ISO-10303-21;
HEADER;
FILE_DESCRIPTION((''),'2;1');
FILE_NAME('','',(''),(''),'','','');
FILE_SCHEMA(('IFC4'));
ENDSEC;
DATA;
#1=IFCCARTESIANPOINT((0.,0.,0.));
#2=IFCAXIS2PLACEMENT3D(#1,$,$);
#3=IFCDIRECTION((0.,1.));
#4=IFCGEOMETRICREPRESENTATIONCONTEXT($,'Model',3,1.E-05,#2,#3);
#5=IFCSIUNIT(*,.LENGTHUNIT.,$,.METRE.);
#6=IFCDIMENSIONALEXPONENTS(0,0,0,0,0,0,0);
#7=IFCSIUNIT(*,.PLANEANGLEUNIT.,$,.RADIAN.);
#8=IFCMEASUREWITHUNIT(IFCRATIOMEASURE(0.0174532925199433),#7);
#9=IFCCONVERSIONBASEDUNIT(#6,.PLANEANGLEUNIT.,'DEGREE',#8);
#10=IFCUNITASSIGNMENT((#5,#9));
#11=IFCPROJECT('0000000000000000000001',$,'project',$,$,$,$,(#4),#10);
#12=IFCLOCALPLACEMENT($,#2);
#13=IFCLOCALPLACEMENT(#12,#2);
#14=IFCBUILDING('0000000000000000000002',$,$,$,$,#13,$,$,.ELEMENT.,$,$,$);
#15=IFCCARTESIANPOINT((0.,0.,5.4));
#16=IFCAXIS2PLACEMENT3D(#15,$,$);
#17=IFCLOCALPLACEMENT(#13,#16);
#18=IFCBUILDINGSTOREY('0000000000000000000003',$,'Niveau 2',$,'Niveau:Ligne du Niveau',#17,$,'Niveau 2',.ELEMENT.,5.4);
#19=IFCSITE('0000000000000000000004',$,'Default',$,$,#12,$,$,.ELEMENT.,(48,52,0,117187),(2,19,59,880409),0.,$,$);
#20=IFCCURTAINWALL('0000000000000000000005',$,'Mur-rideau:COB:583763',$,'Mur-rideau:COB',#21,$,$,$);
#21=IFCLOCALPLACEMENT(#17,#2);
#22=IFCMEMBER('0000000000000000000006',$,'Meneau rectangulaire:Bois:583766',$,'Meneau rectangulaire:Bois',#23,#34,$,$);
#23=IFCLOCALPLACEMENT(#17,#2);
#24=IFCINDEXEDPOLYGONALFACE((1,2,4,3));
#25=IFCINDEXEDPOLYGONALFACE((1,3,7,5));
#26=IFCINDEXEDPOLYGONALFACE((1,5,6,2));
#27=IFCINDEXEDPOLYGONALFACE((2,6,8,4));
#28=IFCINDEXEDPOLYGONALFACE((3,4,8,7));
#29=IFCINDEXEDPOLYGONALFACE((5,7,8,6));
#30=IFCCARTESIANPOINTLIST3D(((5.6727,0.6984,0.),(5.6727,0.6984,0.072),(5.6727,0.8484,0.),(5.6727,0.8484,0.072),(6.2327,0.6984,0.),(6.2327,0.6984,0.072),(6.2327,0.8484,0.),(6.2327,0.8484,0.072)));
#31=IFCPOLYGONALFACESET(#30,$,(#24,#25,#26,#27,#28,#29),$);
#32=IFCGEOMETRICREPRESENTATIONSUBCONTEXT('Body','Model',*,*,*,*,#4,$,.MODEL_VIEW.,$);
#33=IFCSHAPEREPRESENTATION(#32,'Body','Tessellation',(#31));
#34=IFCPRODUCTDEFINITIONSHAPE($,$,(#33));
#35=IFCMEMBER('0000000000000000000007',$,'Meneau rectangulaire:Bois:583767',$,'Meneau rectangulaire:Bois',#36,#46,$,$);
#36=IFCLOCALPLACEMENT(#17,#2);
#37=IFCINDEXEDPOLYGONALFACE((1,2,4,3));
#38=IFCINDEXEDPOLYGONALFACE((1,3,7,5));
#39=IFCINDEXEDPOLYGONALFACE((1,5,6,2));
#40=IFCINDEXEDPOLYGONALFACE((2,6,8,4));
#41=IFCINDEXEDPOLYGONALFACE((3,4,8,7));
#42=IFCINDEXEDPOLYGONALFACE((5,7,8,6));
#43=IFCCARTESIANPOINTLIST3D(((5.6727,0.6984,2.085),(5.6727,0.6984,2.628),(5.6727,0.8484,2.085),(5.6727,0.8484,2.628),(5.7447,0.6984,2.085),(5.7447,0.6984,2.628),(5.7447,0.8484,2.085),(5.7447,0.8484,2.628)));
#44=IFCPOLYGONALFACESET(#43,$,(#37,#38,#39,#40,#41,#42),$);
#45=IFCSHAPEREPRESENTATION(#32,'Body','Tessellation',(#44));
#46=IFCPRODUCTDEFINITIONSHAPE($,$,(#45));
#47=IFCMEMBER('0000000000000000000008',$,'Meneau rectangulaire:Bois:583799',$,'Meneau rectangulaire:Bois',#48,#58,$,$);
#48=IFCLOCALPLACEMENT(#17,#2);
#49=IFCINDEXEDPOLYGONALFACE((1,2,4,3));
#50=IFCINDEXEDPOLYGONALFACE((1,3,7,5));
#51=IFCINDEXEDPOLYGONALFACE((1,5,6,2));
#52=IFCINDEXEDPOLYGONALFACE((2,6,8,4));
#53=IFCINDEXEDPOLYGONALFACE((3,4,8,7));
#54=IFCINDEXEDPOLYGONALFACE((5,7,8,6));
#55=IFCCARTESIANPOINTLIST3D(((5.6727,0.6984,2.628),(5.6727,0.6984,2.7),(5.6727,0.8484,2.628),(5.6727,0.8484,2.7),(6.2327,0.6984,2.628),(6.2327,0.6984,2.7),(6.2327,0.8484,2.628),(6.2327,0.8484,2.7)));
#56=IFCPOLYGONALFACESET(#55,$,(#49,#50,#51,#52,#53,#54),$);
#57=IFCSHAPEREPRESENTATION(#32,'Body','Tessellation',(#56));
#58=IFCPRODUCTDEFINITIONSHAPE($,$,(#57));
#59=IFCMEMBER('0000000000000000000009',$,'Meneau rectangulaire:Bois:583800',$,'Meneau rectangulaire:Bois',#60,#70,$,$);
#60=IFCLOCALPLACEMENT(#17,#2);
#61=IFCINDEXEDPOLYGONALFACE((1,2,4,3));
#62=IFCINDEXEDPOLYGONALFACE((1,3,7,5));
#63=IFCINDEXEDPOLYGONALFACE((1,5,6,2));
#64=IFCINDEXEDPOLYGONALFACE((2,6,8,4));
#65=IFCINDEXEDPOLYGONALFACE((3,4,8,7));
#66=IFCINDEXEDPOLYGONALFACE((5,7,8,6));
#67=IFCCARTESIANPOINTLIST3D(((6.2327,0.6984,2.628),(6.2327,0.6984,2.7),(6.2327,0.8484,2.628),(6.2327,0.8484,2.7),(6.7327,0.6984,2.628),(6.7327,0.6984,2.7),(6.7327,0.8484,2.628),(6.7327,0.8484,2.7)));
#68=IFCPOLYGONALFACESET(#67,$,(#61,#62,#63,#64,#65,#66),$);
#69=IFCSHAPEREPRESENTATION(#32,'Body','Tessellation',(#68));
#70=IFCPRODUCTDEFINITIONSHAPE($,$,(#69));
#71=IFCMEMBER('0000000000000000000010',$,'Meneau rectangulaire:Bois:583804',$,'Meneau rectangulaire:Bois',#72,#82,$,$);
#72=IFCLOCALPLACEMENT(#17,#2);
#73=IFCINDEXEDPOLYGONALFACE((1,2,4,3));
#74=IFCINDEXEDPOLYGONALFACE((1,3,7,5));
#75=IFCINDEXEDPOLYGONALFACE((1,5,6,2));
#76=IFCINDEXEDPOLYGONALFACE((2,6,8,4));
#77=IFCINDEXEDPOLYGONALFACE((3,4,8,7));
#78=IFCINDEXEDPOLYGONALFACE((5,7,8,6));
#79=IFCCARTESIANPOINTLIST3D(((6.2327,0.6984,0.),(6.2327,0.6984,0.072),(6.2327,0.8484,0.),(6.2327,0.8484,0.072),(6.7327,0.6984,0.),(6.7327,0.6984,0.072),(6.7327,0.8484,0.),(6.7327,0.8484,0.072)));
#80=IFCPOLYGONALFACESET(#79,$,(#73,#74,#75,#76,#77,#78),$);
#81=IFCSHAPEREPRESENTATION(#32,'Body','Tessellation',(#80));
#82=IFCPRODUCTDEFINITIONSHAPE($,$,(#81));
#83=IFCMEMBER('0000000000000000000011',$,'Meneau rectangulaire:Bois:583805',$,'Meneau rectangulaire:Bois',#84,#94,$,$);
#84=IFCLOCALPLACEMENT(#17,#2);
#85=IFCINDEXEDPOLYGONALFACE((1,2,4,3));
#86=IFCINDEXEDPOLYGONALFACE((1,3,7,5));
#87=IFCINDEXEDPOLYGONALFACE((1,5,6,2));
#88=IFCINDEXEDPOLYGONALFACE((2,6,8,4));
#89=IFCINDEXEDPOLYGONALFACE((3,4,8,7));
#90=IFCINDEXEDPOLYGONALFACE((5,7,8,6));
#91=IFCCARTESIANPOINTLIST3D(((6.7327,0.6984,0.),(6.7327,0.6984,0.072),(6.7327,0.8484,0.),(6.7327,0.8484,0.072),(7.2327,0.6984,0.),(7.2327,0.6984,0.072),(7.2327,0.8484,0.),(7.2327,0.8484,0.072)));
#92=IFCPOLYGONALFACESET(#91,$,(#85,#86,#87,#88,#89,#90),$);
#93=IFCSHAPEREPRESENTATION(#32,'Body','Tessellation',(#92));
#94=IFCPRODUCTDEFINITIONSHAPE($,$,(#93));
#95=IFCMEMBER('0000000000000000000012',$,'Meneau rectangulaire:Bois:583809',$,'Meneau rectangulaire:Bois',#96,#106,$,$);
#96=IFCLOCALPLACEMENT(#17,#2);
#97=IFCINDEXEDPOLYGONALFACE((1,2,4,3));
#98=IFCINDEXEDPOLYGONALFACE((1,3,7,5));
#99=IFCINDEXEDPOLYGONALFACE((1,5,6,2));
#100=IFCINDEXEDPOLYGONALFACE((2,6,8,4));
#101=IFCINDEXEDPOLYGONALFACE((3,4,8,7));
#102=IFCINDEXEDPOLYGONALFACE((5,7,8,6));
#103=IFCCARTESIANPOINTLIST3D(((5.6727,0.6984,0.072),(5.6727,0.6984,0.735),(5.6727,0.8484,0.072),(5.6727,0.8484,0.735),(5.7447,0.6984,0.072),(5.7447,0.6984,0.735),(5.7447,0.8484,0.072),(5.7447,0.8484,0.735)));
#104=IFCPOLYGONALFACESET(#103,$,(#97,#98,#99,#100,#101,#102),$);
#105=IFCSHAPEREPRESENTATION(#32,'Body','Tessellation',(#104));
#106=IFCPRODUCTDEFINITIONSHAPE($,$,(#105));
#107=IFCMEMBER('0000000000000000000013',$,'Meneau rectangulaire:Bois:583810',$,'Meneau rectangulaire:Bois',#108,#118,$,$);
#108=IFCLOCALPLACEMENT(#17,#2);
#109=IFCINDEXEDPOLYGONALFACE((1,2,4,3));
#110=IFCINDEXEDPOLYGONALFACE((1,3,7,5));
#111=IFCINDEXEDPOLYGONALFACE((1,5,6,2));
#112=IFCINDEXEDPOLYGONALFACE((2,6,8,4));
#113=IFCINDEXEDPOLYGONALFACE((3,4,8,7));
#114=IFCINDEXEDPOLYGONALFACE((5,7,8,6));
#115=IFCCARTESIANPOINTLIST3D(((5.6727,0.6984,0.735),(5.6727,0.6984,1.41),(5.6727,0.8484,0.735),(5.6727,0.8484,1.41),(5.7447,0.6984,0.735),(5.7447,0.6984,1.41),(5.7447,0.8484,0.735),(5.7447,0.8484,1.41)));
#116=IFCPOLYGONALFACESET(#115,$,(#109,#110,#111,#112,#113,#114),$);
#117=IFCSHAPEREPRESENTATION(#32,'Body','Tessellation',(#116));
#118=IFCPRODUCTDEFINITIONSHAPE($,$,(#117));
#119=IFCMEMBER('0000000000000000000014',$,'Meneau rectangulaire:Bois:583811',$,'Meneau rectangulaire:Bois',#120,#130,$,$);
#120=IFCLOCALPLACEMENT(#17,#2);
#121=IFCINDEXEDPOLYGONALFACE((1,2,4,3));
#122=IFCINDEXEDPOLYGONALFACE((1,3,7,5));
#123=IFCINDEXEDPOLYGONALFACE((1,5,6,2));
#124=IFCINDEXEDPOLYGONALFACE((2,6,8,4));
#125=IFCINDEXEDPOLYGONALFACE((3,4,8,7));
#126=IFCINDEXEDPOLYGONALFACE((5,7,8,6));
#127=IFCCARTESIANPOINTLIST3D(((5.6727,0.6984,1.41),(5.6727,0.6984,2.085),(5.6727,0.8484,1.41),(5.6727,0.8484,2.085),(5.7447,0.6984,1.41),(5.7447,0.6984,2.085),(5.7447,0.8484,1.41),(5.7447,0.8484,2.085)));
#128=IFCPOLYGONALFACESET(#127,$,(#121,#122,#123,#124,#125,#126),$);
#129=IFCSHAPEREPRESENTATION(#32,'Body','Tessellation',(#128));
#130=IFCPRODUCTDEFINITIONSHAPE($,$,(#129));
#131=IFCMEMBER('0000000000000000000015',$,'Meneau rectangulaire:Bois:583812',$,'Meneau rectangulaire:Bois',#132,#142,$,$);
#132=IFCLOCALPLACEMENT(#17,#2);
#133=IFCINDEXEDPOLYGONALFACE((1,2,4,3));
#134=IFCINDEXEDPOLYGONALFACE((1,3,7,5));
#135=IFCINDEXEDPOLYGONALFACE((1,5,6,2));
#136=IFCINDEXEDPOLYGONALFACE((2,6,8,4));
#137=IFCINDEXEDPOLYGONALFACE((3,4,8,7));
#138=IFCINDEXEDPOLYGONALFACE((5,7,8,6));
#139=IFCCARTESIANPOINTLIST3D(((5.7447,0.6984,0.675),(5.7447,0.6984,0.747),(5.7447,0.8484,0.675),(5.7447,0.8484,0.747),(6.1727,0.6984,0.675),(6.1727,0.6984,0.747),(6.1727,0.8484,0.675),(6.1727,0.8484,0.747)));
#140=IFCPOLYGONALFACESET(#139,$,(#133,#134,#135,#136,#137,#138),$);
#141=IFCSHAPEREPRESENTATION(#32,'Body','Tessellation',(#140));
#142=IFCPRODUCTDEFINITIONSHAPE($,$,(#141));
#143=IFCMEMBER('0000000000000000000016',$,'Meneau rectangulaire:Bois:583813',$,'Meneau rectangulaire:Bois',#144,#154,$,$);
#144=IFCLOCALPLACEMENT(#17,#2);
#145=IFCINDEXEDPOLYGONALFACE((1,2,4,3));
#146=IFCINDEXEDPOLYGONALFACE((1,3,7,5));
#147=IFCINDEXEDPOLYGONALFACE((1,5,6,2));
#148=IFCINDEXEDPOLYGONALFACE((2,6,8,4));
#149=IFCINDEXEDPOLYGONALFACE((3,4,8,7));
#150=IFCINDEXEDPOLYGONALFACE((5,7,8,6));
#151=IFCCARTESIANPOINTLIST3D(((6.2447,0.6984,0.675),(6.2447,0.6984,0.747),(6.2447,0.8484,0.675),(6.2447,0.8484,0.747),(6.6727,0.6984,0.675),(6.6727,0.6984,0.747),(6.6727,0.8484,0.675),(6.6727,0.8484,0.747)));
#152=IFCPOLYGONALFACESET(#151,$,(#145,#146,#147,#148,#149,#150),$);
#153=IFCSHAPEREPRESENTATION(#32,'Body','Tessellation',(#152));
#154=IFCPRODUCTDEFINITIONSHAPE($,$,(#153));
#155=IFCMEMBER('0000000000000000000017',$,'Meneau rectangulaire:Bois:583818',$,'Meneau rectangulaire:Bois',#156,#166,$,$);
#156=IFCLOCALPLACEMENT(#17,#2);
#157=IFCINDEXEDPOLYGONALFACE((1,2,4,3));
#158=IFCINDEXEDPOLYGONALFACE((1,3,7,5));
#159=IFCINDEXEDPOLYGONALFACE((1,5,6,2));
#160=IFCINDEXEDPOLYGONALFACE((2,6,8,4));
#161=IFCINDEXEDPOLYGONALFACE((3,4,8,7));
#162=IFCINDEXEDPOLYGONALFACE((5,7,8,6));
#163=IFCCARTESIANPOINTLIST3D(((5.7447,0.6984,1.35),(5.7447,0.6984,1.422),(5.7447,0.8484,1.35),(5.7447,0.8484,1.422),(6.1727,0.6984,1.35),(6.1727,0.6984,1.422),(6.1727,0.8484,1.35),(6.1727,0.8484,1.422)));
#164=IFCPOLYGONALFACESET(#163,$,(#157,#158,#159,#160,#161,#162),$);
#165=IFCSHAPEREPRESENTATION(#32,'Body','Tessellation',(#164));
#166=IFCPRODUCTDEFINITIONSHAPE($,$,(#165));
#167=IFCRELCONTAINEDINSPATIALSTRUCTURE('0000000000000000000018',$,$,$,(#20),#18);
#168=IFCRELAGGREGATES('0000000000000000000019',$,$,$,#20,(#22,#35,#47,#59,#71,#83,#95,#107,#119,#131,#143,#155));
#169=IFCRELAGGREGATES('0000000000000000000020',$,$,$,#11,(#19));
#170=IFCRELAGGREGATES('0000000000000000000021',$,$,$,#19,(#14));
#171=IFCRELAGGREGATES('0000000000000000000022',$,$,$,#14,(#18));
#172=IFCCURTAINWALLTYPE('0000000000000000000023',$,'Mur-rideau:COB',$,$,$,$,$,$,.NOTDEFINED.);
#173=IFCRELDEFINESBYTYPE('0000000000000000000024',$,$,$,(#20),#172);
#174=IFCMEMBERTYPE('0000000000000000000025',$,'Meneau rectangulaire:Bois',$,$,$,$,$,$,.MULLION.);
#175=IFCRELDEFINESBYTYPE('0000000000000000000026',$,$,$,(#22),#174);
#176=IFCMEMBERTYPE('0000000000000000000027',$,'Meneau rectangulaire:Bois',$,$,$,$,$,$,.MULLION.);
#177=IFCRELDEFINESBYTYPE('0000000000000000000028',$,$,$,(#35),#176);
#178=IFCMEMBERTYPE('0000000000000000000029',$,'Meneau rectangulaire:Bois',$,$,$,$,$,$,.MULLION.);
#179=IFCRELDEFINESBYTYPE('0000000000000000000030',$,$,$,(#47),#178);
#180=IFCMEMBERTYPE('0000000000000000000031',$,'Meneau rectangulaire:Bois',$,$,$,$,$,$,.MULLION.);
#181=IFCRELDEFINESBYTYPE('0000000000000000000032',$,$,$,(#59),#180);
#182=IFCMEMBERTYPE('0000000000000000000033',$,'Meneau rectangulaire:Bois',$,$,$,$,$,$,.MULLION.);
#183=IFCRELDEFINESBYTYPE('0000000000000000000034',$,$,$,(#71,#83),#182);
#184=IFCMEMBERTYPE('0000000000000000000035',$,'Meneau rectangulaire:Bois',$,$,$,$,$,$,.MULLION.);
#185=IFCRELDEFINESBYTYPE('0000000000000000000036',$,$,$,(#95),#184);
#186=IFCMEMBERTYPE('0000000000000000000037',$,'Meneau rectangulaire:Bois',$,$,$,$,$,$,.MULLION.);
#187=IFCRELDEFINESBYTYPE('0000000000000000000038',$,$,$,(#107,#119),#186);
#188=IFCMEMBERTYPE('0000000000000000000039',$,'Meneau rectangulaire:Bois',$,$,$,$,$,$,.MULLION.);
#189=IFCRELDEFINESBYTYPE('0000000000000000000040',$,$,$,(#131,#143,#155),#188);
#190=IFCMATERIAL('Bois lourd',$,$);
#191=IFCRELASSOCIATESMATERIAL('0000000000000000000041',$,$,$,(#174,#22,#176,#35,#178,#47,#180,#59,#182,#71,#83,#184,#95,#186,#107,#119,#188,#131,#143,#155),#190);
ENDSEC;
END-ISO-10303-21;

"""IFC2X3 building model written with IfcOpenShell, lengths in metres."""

from ifc_helpers import new_model, entity, si_unit, converted_unit, direction, frame, origin, origin_2d_with_axis, place, context, subcontext, project, spatial, rectangle, extrude, source, transform, mapped, material, type_object, type_shapes, element, aggregate, save


model = new_model("IFC2X3")

# Units and contexts
model_context = context("Model", 3, precision=1e-05, world=origin(), true_north=direction((0.0, 1.0)))
body_context = subcontext(model_context, "Body", "Model", "MODEL_VIEW")
ifc_project = project(units=[si_unit("LENGTHUNIT", "METRE"), converted_unit("PLANEANGLEUNIT", "DEGREE", entity("IfcRatioMeasure", 0.0174532925199433), si_unit("PLANEANGLEUNIT", "RADIAN"), dimensions=[0, 0, 0, 0, 0, 0, 0])], contexts=[model_context])

# Site, building, storey
site_placement = place(None, origin())
site = spatial("IfcSite", under=ifc_project, at=site_placement, Name="Default", CompositionType="ELEMENT", RefLatitude=(48, 52, 0, 117187), RefLongitude=(2, 19, 59, 880409), RefElevation=0.0)
building_placement = place(site_placement, origin())
building = spatial("IfcBuilding", under=site, at=building_placement, CompositionType="ELEMENT")
storey_placement = place(building_placement, frame((0.0, 0.0, 5.4)))
storey = spatial("IfcBuildingStorey", under=building, at=storey_placement, Name="Niveau 2", ObjectType="Niveau:Ligne du Niveau", LongName="Niveau 2", CompositionType="ELEMENT", Elevation=5.4)

# Curtain wall, members
curtain_wall_type_1 = type_object("IfcCurtainWallType", Name="Mur-rideau:COB", PredefinedType="NOTDEFINED")
curtain_wall_1_placement = place(storey_placement, frame((0.0, 0.0, -5.4)))
curtain_wall_1 = element("IfcCurtainWall", 1, at=curtain_wall_1_placement, inside=storey, type_object=curtain_wall_type_1, Name="Mur-rideau:COB:583763", ObjectType="Mur-rideau:COB")
ifc_material_1 = material(Name="Bois lourd")
member_type_1 = type_object("IfcMemberType", Name="Meneau rectangulaire:Bois", PredefinedType="MULLION", material=ifc_material_1)
shared_shape_1 = source(origin(), body_context, "Body", "SweptSolid", [
    extrude(rectangle(XDim=0.15, YDim=0.072, at=origin_2d_with_axis()), frame((-0.036, 0.0, -0.56), z_axis=(0.0, 0.0, 1.0), x_axis=(0.0, -1.0, 0.0)), (0.0, 0.0, 1.0), 0.56),
])
type_shapes(member_type_1, [shared_shape_1])
member_1_placement = place(storey_placement, frame((5.6727, 0.7734, 0.0), z_axis=(-1.0, 0.0, 0.0), x_axis=(0.0, 0.0, -1.0)))
member_1 = element("IfcMember", 2, at=member_1_placement, type_object=member_type_1, material=ifc_material_1, Name="Meneau rectangulaire:Bois:583766", ObjectType="Meneau rectangulaire:Bois", context=body_context, shape_type="MappedRepresentation", body=[
    mapped(shared_shape_1, transform((0.0, 0.0, 0.0), scale=1.0)),
])
member_type_2 = type_object("IfcMemberType", Name="Meneau rectangulaire:Bois", PredefinedType="MULLION", material=ifc_material_1)
shared_shape_2 = source(origin(), body_context, "Body", "SweptSolid", [
    extrude(rectangle(XDim=0.15, YDim=0.072, at=origin_2d_with_axis()), frame((-0.036, 0.0, -0.543), z_axis=(0.0, 0.0, 1.0), x_axis=(0.0, -1.0, 0.0)), (0.0, 0.0, 1.0), 0.543),
])
type_shapes(member_type_2, [shared_shape_2])
member_2_placement = place(storey_placement, frame((5.6727, 0.7734, 2.628), z_axis=(0.0, 0.0, 1.0), x_axis=(-1.0, 0.0, 0.0)))
member_2 = element("IfcMember", 3, at=member_2_placement, type_object=member_type_2, material=ifc_material_1, Name="Meneau rectangulaire:Bois:583767", ObjectType="Meneau rectangulaire:Bois", context=body_context, shape_type="MappedRepresentation", body=[
    mapped(shared_shape_2, transform((0.0, 0.0, 0.0), scale=1.0)),
])
member_type_3 = type_object("IfcMemberType", Name="Meneau rectangulaire:Bois", PredefinedType="MULLION", material=ifc_material_1)
shared_shape_3 = source(origin(), body_context, "Body", "SweptSolid", [
    extrude(rectangle(XDim=0.15, YDim=0.072, at=origin_2d_with_axis()), frame((-0.036, 0.0, -0.56), z_axis=(0.0, 0.0, 1.0), x_axis=(0.0, -1.0, 0.0)), (0.0, 0.0, 1.0), 0.56),
])
type_shapes(member_type_3, [shared_shape_3])
member_3_placement = place(storey_placement, frame((6.2327, 0.7734, 2.7), z_axis=(1.0, 0.0, 0.0), x_axis=(0.0, 0.0, 1.0)))
member_3 = element("IfcMember", 4, at=member_3_placement, type_object=member_type_3, material=ifc_material_1, Name="Meneau rectangulaire:Bois:583799", ObjectType="Meneau rectangulaire:Bois", context=body_context, shape_type="MappedRepresentation", body=[
    mapped(shared_shape_3, transform((0.0, 0.0, 0.0), scale=1.0)),
])
member_type_4 = type_object("IfcMemberType", Name="Meneau rectangulaire:Bois", PredefinedType="MULLION", material=ifc_material_1)
shared_shape_4 = source(origin(), body_context, "Body", "SweptSolid", [
    extrude(rectangle(XDim=0.15, YDim=0.072, at=origin_2d_with_axis()), frame((-0.036, 0.0, -0.5), z_axis=(0.0, 0.0, 1.0), x_axis=(0.0, -1.0, 0.0)), (0.0, 0.0, 1.0), 0.5),
])
type_shapes(member_type_4, [shared_shape_4])
member_4_placement = place(storey_placement, frame((6.7327, 0.7734, 2.7), z_axis=(1.0, 0.0, 0.0), x_axis=(0.0, 0.0, 1.0)))
member_4 = element("IfcMember", 5, at=member_4_placement, type_object=member_type_4, material=ifc_material_1, Name="Meneau rectangulaire:Bois:583800", ObjectType="Meneau rectangulaire:Bois", context=body_context, shape_type="MappedRepresentation", body=[
    mapped(shared_shape_4, transform((0.0, 0.0, 0.0), scale=1.0)),
])
member_type_5 = type_object("IfcMemberType", Name="Meneau rectangulaire:Bois", PredefinedType="MULLION", material=ifc_material_1)
shared_shape_5 = source(origin(), body_context, "Body", "SweptSolid", [
    extrude(rectangle(XDim=0.15, YDim=0.072, at=origin_2d_with_axis()), frame((-0.036, 0.0, -0.5), z_axis=(0.0, 0.0, 1.0), x_axis=(0.0, -1.0, 0.0)), (0.0, 0.0, 1.0), 0.5),
])
type_shapes(member_type_5, [shared_shape_5])
member_5_placement = place(storey_placement, frame((6.2327, 0.7734, 0.0), z_axis=(-1.0, 0.0, 0.0), x_axis=(0.0, 0.0, -1.0)))
member_5 = element("IfcMember", 6, at=member_5_placement, type_object=member_type_5, material=ifc_material_1, Name="Meneau rectangulaire:Bois:583804", ObjectType="Meneau rectangulaire:Bois", context=body_context, shape_type="MappedRepresentation", body=[
    mapped(shared_shape_5, transform((0.0, 0.0, 0.0), scale=1.0)),
])
member_6_placement = place(storey_placement, frame((6.7327, 0.7734, 0.0), z_axis=(-1.0, 0.0, 0.0), x_axis=(0.0, 0.0, -1.0)))
member_6 = element("IfcMember", 7, at=member_6_placement, type_object=member_type_5, material=ifc_material_1, Name="Meneau rectangulaire:Bois:583805", ObjectType="Meneau rectangulaire:Bois", context=body_context, shape_type="MappedRepresentation", body=[
    mapped(shared_shape_5, transform((0.0, 0.0, 0.0), scale=1.0)),
])
member_type_6 = type_object("IfcMemberType", Name="Meneau rectangulaire:Bois", PredefinedType="MULLION", material=ifc_material_1)
shared_shape_6 = source(origin(), body_context, "Body", "SweptSolid", [
    extrude(rectangle(XDim=0.15, YDim=0.072, at=origin_2d_with_axis()), frame((-0.036, 0.0, -0.663), z_axis=(0.0, 0.0, 1.0), x_axis=(0.0, -1.0, 0.0)), (0.0, 0.0, 1.0), 0.663),
])
type_shapes(member_type_6, [shared_shape_6])
member_7_placement = place(storey_placement, frame((5.6727, 0.7734, 0.735), z_axis=(0.0, 0.0, 1.0), x_axis=(-1.0, 0.0, 0.0)))
member_7 = element("IfcMember", 8, at=member_7_placement, type_object=member_type_6, material=ifc_material_1, Name="Meneau rectangulaire:Bois:583809", ObjectType="Meneau rectangulaire:Bois", context=body_context, shape_type="MappedRepresentation", body=[
    mapped(shared_shape_6, transform((0.0, 0.0, 0.0), scale=1.0)),
])
member_type_7 = type_object("IfcMemberType", Name="Meneau rectangulaire:Bois", PredefinedType="MULLION", material=ifc_material_1)
shared_shape_7 = source(origin(), body_context, "Body", "SweptSolid", [
    extrude(rectangle(XDim=0.15, YDim=0.072, at=origin_2d_with_axis()), frame((-0.036, 0.0, -0.675), z_axis=(0.0, 0.0, 1.0), x_axis=(0.0, -1.0, 0.0)), (0.0, 0.0, 1.0), 0.675),
])
type_shapes(member_type_7, [shared_shape_7])
member_8_placement = place(storey_placement, frame((5.6727, 0.7734, 1.41), z_axis=(0.0, 0.0, 1.0), x_axis=(-1.0, 0.0, 0.0)))
member_8 = element("IfcMember", 9, at=member_8_placement, type_object=member_type_7, material=ifc_material_1, Name="Meneau rectangulaire:Bois:583810", ObjectType="Meneau rectangulaire:Bois", context=body_context, shape_type="MappedRepresentation", body=[
    mapped(shared_shape_7, transform((0.0, 0.0, 0.0), scale=1.0)),
])
member_9_placement = place(storey_placement, frame((5.6727, 0.7734, 2.085), z_axis=(0.0, 0.0, 1.0), x_axis=(-1.0, 0.0, 0.0)))
member_9 = element("IfcMember", 10, at=member_9_placement, type_object=member_type_7, material=ifc_material_1, Name="Meneau rectangulaire:Bois:583811", ObjectType="Meneau rectangulaire:Bois", context=body_context, shape_type="MappedRepresentation", body=[
    mapped(shared_shape_7, transform((0.0, 0.0, 0.0), scale=1.0)),
])
member_type_8 = type_object("IfcMemberType", Name="Meneau rectangulaire:Bois", PredefinedType="MULLION", material=ifc_material_1)
shared_shape_8 = source(origin(), body_context, "Body", "SweptSolid", [
    extrude(rectangle(XDim=0.15, YDim=0.072, at=origin_2d_with_axis()), frame((-0.024, 0.0, -0.428), z_axis=(0.0, 0.0, 1.0), x_axis=(0.0, -1.0, 0.0)), (0.0, 0.0, 1.0), 0.428),
])
type_shapes(member_type_8, [shared_shape_8])
member_10_placement = place(storey_placement, frame((6.1727, 0.7734, 0.735), z_axis=(1.0, 0.0, 0.0), x_axis=(0.0, 0.0, 1.0)))
member_10 = element("IfcMember", 11, at=member_10_placement, type_object=member_type_8, material=ifc_material_1, Name="Meneau rectangulaire:Bois:583812", ObjectType="Meneau rectangulaire:Bois", context=body_context, shape_type="MappedRepresentation", body=[
    mapped(shared_shape_8, transform((0.0, 0.0, 0.0), scale=1.0)),
])
member_11_placement = place(storey_placement, frame((6.6727, 0.7734, 0.735), z_axis=(1.0, 0.0, 0.0), x_axis=(0.0, 0.0, 1.0)))
member_11 = element("IfcMember", 12, at=member_11_placement, type_object=member_type_8, material=ifc_material_1, Name="Meneau rectangulaire:Bois:583813", ObjectType="Meneau rectangulaire:Bois", context=body_context, shape_type="MappedRepresentation", body=[
    mapped(shared_shape_8, transform((0.0, 0.0, 0.0), scale=1.0)),
])
member_12_placement = place(storey_placement, frame((6.1727, 0.7734, 1.41), z_axis=(1.0, 0.0, 0.0), x_axis=(0.0, 0.0, 1.0)))
member_12 = element("IfcMember", 13, at=member_12_placement, type_object=member_type_8, material=ifc_material_1, Name="Meneau rectangulaire:Bois:583818", ObjectType="Meneau rectangulaire:Bois", context=body_context, shape_type="MappedRepresentation", body=[
    mapped(shared_shape_8, transform((0.0, 0.0, 0.0), scale=1.0)),
])
aggregate(curtain_wall_1, [member_1, member_2, member_3, member_4, member_5, member_6, member_7, member_8, member_9, member_10, member_11, member_12])

save(model, "model.ifc")
